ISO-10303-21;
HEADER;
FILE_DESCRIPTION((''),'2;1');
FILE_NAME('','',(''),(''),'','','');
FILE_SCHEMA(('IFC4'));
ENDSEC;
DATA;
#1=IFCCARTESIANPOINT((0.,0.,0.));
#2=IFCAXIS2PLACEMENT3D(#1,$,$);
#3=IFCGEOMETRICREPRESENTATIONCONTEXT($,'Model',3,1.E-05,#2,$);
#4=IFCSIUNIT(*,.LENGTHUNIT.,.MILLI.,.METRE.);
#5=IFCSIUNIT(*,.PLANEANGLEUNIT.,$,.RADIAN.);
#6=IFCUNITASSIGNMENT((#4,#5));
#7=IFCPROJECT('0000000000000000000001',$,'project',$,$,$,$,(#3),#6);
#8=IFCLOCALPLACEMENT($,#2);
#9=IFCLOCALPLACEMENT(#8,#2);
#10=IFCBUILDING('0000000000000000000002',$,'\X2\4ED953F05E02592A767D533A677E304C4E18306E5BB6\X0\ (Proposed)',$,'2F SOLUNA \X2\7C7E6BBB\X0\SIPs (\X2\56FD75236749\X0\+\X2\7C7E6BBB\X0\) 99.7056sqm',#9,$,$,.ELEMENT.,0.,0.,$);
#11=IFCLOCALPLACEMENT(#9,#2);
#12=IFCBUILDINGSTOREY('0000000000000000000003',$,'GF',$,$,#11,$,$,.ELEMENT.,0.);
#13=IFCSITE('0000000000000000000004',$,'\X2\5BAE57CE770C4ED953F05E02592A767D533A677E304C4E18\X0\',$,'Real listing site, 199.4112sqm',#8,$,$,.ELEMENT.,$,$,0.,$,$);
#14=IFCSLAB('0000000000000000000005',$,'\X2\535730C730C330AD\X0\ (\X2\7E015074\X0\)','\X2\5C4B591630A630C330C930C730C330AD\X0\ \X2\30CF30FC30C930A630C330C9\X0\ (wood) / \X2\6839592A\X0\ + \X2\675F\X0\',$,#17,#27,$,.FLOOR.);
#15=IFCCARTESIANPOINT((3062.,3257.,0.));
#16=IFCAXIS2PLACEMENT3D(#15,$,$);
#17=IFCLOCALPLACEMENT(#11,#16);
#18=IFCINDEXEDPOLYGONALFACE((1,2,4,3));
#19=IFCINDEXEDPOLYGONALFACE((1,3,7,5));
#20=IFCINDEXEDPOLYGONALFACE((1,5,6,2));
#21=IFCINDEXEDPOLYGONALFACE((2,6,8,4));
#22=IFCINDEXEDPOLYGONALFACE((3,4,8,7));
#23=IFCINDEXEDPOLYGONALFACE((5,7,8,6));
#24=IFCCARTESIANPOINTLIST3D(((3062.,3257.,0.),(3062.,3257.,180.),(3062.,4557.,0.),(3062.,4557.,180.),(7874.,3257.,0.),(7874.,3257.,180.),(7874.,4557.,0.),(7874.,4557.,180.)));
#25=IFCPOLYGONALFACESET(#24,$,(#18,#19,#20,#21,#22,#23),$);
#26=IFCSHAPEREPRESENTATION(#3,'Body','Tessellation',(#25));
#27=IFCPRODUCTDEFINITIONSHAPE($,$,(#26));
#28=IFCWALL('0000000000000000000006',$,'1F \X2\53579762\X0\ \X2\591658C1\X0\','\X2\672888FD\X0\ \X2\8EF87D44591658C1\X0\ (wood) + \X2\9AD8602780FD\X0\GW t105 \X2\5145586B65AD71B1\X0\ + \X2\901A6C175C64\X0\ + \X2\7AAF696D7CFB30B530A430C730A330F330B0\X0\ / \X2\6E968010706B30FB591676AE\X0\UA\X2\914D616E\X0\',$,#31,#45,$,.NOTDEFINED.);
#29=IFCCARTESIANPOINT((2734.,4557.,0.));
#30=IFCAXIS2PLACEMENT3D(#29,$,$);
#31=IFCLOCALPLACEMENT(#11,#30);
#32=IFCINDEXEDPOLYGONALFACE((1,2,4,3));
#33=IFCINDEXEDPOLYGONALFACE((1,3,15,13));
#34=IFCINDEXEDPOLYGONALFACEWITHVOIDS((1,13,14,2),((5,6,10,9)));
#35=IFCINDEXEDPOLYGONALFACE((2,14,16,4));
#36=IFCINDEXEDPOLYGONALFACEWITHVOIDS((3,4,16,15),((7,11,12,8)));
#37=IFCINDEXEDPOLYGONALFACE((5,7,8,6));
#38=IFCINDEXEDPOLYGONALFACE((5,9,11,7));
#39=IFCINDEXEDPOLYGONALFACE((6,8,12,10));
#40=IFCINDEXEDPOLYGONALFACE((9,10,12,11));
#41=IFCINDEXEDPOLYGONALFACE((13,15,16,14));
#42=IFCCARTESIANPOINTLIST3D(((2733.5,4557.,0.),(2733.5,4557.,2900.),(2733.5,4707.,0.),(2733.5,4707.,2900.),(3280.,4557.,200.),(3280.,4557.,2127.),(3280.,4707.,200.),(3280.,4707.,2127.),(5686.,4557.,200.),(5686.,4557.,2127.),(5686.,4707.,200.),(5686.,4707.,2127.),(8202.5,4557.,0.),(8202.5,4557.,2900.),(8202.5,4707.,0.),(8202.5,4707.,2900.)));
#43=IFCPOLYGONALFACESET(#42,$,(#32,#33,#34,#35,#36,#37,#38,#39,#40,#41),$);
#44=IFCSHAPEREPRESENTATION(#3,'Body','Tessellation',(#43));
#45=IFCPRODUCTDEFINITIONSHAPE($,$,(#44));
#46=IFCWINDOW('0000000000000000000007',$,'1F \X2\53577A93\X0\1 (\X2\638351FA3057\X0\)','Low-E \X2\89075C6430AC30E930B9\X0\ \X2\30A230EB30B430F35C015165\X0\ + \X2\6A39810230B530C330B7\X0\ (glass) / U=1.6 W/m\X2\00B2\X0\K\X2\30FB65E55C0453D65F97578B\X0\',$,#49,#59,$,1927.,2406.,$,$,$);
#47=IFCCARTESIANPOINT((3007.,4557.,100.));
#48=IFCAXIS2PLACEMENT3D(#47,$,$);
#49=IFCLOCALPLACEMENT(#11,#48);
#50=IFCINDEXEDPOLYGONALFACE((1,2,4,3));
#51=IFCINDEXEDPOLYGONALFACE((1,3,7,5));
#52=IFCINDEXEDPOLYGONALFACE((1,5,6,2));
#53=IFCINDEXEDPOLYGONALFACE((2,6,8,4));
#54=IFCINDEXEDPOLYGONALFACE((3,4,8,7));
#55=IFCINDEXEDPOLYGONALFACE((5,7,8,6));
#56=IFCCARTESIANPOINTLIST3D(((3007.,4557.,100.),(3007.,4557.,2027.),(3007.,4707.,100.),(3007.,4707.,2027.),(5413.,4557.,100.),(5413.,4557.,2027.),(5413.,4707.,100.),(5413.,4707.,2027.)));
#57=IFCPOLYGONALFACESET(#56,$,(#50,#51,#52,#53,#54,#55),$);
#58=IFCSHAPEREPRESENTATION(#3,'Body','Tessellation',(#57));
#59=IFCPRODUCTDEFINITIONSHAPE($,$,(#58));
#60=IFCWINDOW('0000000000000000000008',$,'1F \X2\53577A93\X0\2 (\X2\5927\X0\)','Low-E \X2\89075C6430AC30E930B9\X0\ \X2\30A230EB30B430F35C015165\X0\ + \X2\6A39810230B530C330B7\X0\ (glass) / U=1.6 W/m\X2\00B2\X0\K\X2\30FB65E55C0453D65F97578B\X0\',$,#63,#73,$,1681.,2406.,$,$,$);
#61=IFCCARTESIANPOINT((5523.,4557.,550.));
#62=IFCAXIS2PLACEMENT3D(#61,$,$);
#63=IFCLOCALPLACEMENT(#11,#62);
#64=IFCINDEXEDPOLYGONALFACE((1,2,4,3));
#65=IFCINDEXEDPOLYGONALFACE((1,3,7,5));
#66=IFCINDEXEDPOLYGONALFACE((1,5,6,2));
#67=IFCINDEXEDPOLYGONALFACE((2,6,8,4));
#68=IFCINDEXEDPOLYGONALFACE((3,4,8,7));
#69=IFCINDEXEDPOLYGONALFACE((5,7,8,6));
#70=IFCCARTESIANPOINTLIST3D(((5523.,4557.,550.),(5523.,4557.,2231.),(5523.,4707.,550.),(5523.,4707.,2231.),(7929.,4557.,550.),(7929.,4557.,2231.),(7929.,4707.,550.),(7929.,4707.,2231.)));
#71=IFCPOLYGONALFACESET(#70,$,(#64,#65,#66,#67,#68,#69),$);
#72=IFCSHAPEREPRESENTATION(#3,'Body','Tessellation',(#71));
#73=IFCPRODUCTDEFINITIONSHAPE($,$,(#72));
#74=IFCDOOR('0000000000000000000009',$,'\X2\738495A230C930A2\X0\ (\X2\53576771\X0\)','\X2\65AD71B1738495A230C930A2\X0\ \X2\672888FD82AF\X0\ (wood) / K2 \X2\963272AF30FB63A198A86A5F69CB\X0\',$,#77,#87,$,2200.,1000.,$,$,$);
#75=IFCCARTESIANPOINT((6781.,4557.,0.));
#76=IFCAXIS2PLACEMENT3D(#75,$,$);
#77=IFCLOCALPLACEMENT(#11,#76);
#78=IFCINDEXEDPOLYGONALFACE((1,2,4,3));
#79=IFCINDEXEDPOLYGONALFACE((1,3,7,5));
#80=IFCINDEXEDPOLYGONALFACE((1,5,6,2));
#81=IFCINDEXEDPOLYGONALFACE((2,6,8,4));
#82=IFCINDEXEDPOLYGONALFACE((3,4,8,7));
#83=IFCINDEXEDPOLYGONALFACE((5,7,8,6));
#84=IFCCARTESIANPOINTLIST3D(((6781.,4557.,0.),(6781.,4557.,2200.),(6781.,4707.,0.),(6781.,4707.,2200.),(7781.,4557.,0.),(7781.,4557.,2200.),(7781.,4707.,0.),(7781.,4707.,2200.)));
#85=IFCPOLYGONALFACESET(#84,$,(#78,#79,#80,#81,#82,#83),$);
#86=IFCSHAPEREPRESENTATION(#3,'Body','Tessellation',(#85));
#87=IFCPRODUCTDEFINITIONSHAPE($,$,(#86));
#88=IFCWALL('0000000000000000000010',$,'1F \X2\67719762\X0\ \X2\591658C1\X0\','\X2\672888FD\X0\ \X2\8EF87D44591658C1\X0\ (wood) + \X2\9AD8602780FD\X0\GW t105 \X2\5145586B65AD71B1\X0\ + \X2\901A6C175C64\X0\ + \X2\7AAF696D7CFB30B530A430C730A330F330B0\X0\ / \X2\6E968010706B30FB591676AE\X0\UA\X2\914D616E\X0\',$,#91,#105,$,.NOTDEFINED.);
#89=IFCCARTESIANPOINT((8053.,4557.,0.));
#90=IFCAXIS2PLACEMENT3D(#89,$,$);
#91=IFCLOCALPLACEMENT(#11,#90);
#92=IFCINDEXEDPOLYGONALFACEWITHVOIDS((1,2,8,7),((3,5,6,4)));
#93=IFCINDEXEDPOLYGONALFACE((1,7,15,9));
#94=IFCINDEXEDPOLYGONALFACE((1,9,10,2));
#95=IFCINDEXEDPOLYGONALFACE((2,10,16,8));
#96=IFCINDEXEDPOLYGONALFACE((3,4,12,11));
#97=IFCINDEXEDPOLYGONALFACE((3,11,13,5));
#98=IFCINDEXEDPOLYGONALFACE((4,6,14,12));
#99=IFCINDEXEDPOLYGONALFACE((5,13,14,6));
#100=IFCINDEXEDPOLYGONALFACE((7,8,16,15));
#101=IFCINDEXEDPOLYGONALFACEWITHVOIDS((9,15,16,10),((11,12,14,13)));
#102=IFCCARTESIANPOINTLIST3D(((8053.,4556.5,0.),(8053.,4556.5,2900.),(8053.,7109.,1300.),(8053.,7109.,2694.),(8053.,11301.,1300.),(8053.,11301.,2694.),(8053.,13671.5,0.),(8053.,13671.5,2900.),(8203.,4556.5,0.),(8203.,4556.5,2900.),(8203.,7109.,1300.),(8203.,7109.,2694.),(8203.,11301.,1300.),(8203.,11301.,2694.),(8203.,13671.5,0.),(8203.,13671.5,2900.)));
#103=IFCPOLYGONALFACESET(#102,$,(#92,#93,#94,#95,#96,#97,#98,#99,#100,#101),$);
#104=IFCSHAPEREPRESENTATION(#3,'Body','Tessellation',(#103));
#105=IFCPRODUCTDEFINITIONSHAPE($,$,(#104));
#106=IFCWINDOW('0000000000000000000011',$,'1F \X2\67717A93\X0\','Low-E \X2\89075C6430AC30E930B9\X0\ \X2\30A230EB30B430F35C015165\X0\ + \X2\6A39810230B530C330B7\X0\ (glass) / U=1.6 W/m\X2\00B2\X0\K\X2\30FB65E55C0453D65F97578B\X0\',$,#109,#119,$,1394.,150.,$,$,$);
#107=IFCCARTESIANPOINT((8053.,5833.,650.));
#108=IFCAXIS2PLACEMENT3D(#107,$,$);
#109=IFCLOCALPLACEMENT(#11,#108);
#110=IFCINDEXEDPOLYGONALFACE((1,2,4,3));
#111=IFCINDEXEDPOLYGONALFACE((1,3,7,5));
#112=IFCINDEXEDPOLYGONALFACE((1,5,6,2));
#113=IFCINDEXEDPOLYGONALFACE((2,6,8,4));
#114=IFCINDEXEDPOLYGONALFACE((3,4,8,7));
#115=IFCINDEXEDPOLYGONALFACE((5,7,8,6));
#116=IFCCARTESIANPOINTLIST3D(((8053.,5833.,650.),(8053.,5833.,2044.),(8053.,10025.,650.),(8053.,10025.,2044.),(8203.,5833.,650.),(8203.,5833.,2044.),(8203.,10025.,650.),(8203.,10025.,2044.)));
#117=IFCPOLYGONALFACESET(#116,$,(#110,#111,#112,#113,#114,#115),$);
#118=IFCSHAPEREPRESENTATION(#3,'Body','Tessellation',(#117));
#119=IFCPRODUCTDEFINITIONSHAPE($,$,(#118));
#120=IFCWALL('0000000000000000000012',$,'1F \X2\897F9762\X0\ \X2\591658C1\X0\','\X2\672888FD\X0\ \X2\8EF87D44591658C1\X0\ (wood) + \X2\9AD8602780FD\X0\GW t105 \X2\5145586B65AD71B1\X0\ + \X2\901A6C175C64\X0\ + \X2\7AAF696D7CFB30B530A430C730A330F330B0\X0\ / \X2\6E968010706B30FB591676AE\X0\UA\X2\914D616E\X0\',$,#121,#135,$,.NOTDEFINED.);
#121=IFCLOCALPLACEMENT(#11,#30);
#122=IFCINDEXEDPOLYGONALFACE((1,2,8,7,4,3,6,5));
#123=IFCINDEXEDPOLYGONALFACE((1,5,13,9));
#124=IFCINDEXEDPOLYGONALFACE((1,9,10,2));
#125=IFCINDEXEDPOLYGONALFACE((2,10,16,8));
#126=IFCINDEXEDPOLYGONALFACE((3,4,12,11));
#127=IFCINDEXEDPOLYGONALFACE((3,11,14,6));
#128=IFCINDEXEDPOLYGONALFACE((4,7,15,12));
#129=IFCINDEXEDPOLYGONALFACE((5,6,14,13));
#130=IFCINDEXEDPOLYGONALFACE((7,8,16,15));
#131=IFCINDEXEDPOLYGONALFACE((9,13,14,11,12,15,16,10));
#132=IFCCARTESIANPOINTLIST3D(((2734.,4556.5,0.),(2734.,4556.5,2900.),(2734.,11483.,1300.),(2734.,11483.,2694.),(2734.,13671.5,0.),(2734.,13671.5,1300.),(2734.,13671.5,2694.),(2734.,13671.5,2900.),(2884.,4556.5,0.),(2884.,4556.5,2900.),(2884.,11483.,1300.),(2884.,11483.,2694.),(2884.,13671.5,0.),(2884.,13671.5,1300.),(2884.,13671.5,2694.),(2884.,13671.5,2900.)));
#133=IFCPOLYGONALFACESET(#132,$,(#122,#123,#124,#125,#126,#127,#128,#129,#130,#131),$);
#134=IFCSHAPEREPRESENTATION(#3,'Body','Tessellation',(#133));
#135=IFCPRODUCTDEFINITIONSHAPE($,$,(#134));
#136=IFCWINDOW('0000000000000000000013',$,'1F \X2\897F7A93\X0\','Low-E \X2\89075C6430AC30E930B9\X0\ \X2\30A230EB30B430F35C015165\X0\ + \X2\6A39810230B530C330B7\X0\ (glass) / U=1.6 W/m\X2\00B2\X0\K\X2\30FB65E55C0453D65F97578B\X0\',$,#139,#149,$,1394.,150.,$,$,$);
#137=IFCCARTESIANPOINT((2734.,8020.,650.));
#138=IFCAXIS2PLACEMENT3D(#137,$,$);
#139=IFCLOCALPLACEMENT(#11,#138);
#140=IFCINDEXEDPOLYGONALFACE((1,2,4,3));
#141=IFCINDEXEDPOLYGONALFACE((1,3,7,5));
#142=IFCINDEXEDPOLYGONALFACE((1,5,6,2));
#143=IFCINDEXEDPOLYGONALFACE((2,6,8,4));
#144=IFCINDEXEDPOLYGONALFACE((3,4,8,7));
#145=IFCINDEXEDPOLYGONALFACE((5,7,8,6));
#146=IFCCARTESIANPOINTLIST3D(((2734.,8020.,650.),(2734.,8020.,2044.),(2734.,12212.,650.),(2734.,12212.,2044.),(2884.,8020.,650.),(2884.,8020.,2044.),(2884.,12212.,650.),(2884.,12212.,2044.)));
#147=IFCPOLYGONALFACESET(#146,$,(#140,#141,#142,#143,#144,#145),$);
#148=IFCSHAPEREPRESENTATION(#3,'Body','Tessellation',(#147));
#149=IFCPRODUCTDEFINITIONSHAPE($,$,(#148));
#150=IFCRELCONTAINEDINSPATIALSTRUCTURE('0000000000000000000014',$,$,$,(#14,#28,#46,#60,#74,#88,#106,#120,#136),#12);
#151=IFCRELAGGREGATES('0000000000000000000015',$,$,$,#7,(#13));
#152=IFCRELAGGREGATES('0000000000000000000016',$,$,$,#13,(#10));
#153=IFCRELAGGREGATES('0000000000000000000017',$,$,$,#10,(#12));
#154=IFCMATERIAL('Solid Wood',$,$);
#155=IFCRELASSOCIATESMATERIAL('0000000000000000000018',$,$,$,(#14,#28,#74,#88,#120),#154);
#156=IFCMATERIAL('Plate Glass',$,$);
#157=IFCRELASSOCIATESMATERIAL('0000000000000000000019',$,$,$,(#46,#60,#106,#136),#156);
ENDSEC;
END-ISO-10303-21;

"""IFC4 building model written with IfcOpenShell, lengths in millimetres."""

from ifc_helpers import new_model, si_unit, frame, frame_2d, origin, place, context, project, spatial, rectangle, extrude, material, element, fill, save


model = new_model("IFC4")

# Units and contexts
model_context = context("Model", 3, precision=1e-05, world=origin())
ifc_project = project(units=[si_unit("LENGTHUNIT", "METRE", prefix="MILLI"), si_unit("PLANEANGLEUNIT", "RADIAN")], contexts=[model_context])

# Site, building, storey
site_placement = place(None, origin())
site = spatial("IfcSite", under=ifc_project, at=site_placement, Name="宮城県仙台市太白区松が丘", ObjectType="Real listing site, 199.4112sqm", CompositionType="ELEMENT", RefElevation=0.0)
building_placement = place(site_placement, origin())
building = spatial("IfcBuilding", under=site, at=building_placement, Name="仙台市太白区松が丘の家 (Proposed)", ObjectType="2F SOLUNA 籾殻SIPs (国産杉+籾殻) 99.7056sqm", CompositionType="ELEMENT", ElevationOfRefHeight=0.0, ElevationOfTerrain=0.0)
storey_placement = place(building_placement, origin())
storey = spatial("IfcBuildingStorey", under=building, at=storey_placement, Name="GF", CompositionType="ELEMENT", Elevation=0.0)

# Slab
ifc_material_1 = material(Name="Solid Wood")
slab_1_placement = place(storey_placement, frame((3062.0, 3257.0, 0.0)))
element("IfcSlab", 1, at=slab_1_placement, inside=storey, material=ifc_material_1, Name="南デッキ (縁側)", Description="屋外ウッドデッキ ハードウッド (wood) / 根太 + 束", PredefinedType="FLOOR", context=model_context, shape_type="SweptSolid", body=[
    extrude(rectangle(XDim=4812.0, YDim=1300.0, at=frame_2d((2406.0, 650.0))), frame((3062.0, 3257.0, 0.0)), (0.0, 0.0, 1.0), 180.0),
])

# Wall, openings, windows, door
wall_1_placement = place(storey_placement, frame((2734.0, 4557.0, 0.0)))
wall_1 = element("IfcWall", 2, at=wall_1_placement, inside=storey, material=ifc_material_1, Name="1F 南面 外壁", Description="木製 軸組外壁 (wood) + 高性能GW t105 充填断熱 + 通気層 + 窯業系サイディング / 準耐火・外皮UA配慮", PredefinedType="NOTDEFINED", context=model_context, shape_type="SweptSolid", body=[
    extrude(rectangle(XDim=5469.0, YDim=150.0, at=frame_2d((2734.0, 75.0))), frame((2734.0, 4557.0, 0.0)), (0.0, 0.0, 1.0), 2900.0),
])
opening_1_placement = place(storey_placement, frame((3007.0, 4557.0, 100.0)))
opening_1 = element("IfcOpeningElement", 3, at=opening_1_placement, cuts=wall_1, PredefinedType="NOTDEFINED", context=model_context, shape_type="SweptSolid", body=[
    extrude(rectangle(XDim=2406.0, YDim=150.0, at=frame_2d((1203.0, 75.0))), frame((3007.0, 4557.0, 100.0)), (0.0, 0.0, 1.0), 1927.0),
])
opening_2_placement = place(storey_placement, frame((5523.0, 4557.0, 550.0)))
opening_2 = element("IfcOpeningElement", 4, at=opening_2_placement, cuts=wall_1, PredefinedType="NOTDEFINED", context=model_context, shape_type="SweptSolid", body=[
    extrude(rectangle(XDim=2406.0, YDim=150.0, at=frame_2d((1203.0, 75.0))), frame((5523.0, 4557.0, 550.0)), (0.0, 0.0, 1.0), 1681.0),
])
opening_3_placement = place(storey_placement, frame((6781.0, 4557.0, 0.0)))
opening_3 = element("IfcOpeningElement", 5, at=opening_3_placement, cuts=wall_1, PredefinedType="NOTDEFINED", context=model_context, shape_type="SweptSolid", body=[
    extrude(rectangle(XDim=1000.0, YDim=150.0, at=frame_2d((500.0, 75.0))), frame((6781.0, 4557.0, 0.0)), (0.0, 0.0, 1.0), 2200.0),
])
ifc_material_2 = material(Name="Plate Glass")
window_1_placement = place(storey_placement, frame((3007.0, 4557.0, 100.0)))
window_1 = element("IfcWindow", 6, at=window_1_placement, inside=storey, material=ifc_material_2, Name="1F 南窓1 (掃出し)", Description="Low-E 複層ガラス アルゴン封入 + 樹脂サッシ (glass) / U=1.6 W/m²K・日射取得型", OverallHeight=1927.0, OverallWidth=2406.0, context=model_context, shape_type="SweptSolid", body=[
    extrude(rectangle(XDim=2406.0, YDim=150.0, at=frame_2d((1203.0, 75.0))), frame((3007.0, 4557.0, 100.0)), (0.0, 0.0, 1.0), 1927.0),
])
fill(opening_1, window_1)
window_2_placement = place(storey_placement, frame((5523.0, 4557.0, 550.0)))
window_2 = element("IfcWindow", 7, at=window_2_placement, inside=storey, material=ifc_material_2, Name="1F 南窓2 (大)", Description="Low-E 複層ガラス アルゴン封入 + 樹脂サッシ (glass) / U=1.6 W/m²K・日射取得型", OverallHeight=1681.0, OverallWidth=2406.0, context=model_context, shape_type="SweptSolid", body=[
    extrude(rectangle(XDim=2406.0, YDim=150.0, at=frame_2d((1203.0, 75.0))), frame((5523.0, 4557.0, 550.0)), (0.0, 0.0, 1.0), 1681.0),
])
fill(opening_2, window_2)
door_placement = place(storey_placement, frame((6781.0, 4557.0, 0.0)))
door = element("IfcDoor", 8, at=door_placement, inside=storey, material=ifc_material_1, Name="玄関ドア (南東)", Description="断熱玄関ドア 木製芯 (wood) / K2 防犯・採風機構", OverallHeight=2200.0, OverallWidth=1000.0, context=model_context, shape_type="SweptSolid", body=[
    extrude(rectangle(XDim=1000.0, YDim=150.0, at=frame_2d((500.0, 75.0))), frame((6781.0, 4557.0, 0.0)), (0.0, 0.0, 1.0), 2200.0),
])
fill(opening_3, door)

# Walls, openings, windows
wall_2_placement = place(storey_placement, frame((8053.0, 4557.0, 0.0)))
wall_2 = element("IfcWall", 9, at=wall_2_placement, inside=storey, material=ifc_material_1, Name="1F 東面 外壁", Description="木製 軸組外壁 (wood) + 高性能GW t105 充填断熱 + 通気層 + 窯業系サイディング / 準耐火・外皮UA配慮", PredefinedType="NOTDEFINED", context=model_context, shape_type="SweptSolid", body=[
    extrude(rectangle(XDim=150.0, YDim=9115.0, at=frame_2d((75.0, 4557.0))), frame((8053.0, 4557.0, 0.0)), (0.0, 0.0, 1.0), 2900.0),
])
opening_4_placement = place(storey_placement, frame((8053.0, 5833.0, 650.0)))
opening_4 = element("IfcOpeningElement", 10, at=opening_4_placement, cuts=wall_2, PredefinedType="NOTDEFINED", context=model_context, shape_type="SweptSolid", body=[
    extrude(rectangle(XDim=150.0, YDim=4192.0, at=frame_2d((75.0, 2096.0))), frame((8053.0, 5833.0, 650.0)), (0.0, 0.0, 1.0), 1394.0),
])
window_3_placement = place(storey_placement, frame((8053.0, 5833.0, 650.0)))
window_3 = element("IfcWindow", 11, at=window_3_placement, inside=storey, material=ifc_material_2, Name="1F 東窓", Description="Low-E 複層ガラス アルゴン封入 + 樹脂サッシ (glass) / U=1.6 W/m²K・日射取得型", OverallHeight=1394.0, OverallWidth=150.0, context=model_context, shape_type="SweptSolid", body=[
    extrude(rectangle(XDim=150.0, YDim=4192.0, at=frame_2d((75.0, 2096.0))), frame((8053.0, 5833.0, 650.0)), (0.0, 0.0, 1.0), 1394.0),
])
fill(opening_4, window_3)
wall_3_placement = place(storey_placement, frame((2734.0, 4557.0, 0.0)))
wall_3 = element("IfcWall", 12, at=wall_3_placement, inside=storey, material=ifc_material_1, Name="1F 西面 外壁", Description="木製 軸組外壁 (wood) + 高性能GW t105 充填断熱 + 通気層 + 窯業系サイディング / 準耐火・外皮UA配慮", PredefinedType="NOTDEFINED", context=model_context, shape_type="SweptSolid", body=[
    extrude(rectangle(XDim=150.0, YDim=9115.0, at=frame_2d((75.0, 4557.0))), frame((2734.0, 4557.0, 0.0)), (0.0, 0.0, 1.0), 2900.0),
])
opening_5_placement = place(storey_placement, frame((2734.0, 8020.0, 650.0)))
opening_5 = element("IfcOpeningElement", 13, at=opening_5_placement, cuts=wall_3, PredefinedType="NOTDEFINED", context=model_context, shape_type="SweptSolid", body=[
    extrude(rectangle(XDim=150.0, YDim=4192.0, at=frame_2d((75.0, 2096.0))), frame((2734.0, 8020.0, 650.0)), (0.0, 0.0, 1.0), 1394.0),
])
window_4_placement = place(storey_placement, frame((2734.0, 8020.0, 650.0)))
window_4 = element("IfcWindow", 14, at=window_4_placement, inside=storey, material=ifc_material_2, Name="1F 西窓", Description="Low-E 複層ガラス アルゴン封入 + 樹脂サッシ (glass) / U=1.6 W/m²K・日射取得型", OverallHeight=1394.0, OverallWidth=150.0, context=model_context, shape_type="SweptSolid", body=[
    extrude(rectangle(XDim=150.0, YDim=4192.0, at=frame_2d((75.0, 2096.0))), frame((2734.0, 8020.0, 650.0)), (0.0, 0.0, 1.0), 1394.0),
])
fill(opening_5, window_4)

save(model, "model.ifc")
